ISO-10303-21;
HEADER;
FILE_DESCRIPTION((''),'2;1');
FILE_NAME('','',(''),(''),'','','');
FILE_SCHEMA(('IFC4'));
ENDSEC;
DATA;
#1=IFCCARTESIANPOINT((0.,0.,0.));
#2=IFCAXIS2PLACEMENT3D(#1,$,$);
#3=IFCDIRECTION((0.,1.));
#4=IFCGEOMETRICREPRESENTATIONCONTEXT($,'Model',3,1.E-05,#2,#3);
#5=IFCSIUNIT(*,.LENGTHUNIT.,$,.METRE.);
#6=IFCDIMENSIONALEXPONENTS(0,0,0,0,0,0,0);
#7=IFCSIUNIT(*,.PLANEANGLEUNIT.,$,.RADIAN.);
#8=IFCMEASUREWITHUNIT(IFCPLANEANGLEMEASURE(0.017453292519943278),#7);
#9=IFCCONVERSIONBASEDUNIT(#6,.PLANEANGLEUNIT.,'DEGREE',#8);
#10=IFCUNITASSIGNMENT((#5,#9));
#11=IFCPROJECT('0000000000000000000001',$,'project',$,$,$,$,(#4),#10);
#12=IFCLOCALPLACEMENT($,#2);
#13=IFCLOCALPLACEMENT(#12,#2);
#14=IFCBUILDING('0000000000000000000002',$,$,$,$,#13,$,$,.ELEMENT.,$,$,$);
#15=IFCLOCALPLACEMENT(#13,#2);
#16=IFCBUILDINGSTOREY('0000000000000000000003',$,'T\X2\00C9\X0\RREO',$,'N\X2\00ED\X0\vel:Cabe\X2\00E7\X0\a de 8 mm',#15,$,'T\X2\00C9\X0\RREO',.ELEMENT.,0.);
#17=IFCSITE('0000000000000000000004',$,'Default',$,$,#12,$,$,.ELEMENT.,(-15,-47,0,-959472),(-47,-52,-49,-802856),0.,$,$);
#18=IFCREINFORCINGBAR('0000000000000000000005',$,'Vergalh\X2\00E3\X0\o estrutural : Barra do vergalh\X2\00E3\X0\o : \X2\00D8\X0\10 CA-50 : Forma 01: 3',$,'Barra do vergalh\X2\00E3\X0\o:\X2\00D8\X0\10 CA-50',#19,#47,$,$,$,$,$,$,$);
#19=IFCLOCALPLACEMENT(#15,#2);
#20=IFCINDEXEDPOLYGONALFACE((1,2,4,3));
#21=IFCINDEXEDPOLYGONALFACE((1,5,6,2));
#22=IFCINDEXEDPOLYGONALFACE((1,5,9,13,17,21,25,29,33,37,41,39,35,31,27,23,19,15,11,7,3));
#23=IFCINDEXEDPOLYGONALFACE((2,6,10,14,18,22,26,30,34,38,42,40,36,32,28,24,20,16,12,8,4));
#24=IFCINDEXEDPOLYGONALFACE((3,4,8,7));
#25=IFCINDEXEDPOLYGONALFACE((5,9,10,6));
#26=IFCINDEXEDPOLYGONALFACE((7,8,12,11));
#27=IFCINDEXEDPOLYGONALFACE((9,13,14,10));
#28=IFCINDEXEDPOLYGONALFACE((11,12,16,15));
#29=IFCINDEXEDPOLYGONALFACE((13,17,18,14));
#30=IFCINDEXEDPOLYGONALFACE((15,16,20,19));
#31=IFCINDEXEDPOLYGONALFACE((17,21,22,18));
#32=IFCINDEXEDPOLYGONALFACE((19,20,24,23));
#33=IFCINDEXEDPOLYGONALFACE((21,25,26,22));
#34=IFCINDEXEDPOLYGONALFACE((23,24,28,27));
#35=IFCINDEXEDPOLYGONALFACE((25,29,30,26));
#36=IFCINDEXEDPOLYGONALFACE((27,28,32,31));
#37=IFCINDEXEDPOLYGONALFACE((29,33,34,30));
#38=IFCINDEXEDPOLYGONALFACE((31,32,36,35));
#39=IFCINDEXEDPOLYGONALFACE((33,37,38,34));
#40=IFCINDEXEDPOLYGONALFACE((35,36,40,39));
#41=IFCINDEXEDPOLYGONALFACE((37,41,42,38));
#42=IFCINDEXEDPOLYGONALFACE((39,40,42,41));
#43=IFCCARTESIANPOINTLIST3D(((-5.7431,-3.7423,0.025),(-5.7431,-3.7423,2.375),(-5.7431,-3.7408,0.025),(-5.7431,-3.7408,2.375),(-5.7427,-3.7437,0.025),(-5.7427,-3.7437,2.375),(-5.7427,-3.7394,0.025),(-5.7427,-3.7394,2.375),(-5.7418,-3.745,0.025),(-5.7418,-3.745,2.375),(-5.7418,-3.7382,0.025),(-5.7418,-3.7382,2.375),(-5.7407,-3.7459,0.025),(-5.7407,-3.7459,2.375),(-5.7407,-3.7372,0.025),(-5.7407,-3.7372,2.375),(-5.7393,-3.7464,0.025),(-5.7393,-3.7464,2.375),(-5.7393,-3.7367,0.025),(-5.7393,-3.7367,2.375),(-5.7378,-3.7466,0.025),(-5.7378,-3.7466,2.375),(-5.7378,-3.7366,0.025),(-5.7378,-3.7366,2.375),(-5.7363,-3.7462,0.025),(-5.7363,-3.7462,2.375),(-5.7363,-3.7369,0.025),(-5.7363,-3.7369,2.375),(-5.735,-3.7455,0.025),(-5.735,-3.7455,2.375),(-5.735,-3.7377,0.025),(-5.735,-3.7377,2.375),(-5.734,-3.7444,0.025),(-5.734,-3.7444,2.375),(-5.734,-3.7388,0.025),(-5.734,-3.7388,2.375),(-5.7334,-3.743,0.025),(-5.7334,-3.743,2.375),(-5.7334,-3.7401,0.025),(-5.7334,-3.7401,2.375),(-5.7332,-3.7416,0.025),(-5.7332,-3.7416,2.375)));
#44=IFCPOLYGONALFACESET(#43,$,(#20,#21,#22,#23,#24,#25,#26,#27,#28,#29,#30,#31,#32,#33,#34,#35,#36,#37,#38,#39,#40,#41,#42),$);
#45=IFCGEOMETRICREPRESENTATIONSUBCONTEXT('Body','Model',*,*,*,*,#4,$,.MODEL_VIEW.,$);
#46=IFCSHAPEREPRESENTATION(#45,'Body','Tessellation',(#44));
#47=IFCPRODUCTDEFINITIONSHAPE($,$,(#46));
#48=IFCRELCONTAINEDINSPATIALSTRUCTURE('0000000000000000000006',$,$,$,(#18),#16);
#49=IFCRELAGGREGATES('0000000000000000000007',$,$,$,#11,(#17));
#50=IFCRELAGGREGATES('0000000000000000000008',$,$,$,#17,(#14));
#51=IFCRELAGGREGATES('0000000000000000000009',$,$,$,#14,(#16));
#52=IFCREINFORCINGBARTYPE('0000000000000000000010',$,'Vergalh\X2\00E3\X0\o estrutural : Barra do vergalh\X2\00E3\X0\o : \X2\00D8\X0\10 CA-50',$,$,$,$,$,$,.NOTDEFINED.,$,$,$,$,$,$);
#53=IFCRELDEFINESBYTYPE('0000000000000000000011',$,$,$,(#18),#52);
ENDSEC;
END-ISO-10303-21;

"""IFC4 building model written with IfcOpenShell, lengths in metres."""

from ifc_helpers import new_model, entity, si_unit, converted_unit, direction, origin, place, context, subcontext, project, spatial, type_object, element, save


model = new_model("IFC4")

# Units and contexts
model_context = context("Model", 3, precision=1e-05, world=origin(), true_north=direction((0.0, 1.0)))
body_context = subcontext(model_context, "Body", "Model", "MODEL_VIEW")
ifc_project = project(units=[si_unit("LENGTHUNIT", "METRE"), converted_unit("PLANEANGLEUNIT", "DEGREE", entity("IfcPlaneAngleMeasure", 0.017453292519943278), si_unit("PLANEANGLEUNIT", "RADIAN"), dimensions=[0, 0, 0, 0, 0, 0, 0])], contexts=[model_context])

# Site, building, storey
site_placement = place(None, origin())
site = spatial("IfcSite", under=ifc_project, at=site_placement, Name="Default", CompositionType="ELEMENT", RefLatitude=(-15, -47, 0, -959472), RefLongitude=(-47, -52, -49, -802856), RefElevation=0.0)
building_placement = place(site_placement, origin())
building = spatial("IfcBuilding", under=site, at=building_placement, CompositionType="ELEMENT")
storey_placement = place(building_placement, origin())
storey = spatial("IfcBuildingStorey", under=building, at=storey_placement, Name="TÉRREO", ObjectType="Nível:Cabeça de 8 mm", LongName="TÉRREO", CompositionType="ELEMENT", Elevation=0.0)

# Reinforcing bar
reinforcing_bar_type_1 = type_object("IfcReinforcingBarType", Name="Vergalhão estrutural : Barra do vergalhão : Ø10 CA-50", PredefinedType="NOTDEFINED")
reinforcing_bar_1_placement = place(storey_placement, origin())
element("IfcReinforcingBar", 1, at=reinforcing_bar_1_placement, inside=storey, type_object=reinforcing_bar_type_1, Name="Vergalhão estrutural : Barra do vergalhão : Ø10 CA-50 : Forma 01: 3", ObjectType="Barra do vergalhão:Ø10 CA-50", context=body_context, shape_type="AdvancedSweptSolid", body=[
    entity("IfcSweptDiskSolid", entity("IfcIndexedPolyCurve", entity("IfcCartesianPointList3D", [[-5.7382, -3.7416, 0.025], [-5.7382, -3.7416, 2.375]]), None, False), 0.005, None, 0.0, 1.0),
])

save(model, "model.ifc")
